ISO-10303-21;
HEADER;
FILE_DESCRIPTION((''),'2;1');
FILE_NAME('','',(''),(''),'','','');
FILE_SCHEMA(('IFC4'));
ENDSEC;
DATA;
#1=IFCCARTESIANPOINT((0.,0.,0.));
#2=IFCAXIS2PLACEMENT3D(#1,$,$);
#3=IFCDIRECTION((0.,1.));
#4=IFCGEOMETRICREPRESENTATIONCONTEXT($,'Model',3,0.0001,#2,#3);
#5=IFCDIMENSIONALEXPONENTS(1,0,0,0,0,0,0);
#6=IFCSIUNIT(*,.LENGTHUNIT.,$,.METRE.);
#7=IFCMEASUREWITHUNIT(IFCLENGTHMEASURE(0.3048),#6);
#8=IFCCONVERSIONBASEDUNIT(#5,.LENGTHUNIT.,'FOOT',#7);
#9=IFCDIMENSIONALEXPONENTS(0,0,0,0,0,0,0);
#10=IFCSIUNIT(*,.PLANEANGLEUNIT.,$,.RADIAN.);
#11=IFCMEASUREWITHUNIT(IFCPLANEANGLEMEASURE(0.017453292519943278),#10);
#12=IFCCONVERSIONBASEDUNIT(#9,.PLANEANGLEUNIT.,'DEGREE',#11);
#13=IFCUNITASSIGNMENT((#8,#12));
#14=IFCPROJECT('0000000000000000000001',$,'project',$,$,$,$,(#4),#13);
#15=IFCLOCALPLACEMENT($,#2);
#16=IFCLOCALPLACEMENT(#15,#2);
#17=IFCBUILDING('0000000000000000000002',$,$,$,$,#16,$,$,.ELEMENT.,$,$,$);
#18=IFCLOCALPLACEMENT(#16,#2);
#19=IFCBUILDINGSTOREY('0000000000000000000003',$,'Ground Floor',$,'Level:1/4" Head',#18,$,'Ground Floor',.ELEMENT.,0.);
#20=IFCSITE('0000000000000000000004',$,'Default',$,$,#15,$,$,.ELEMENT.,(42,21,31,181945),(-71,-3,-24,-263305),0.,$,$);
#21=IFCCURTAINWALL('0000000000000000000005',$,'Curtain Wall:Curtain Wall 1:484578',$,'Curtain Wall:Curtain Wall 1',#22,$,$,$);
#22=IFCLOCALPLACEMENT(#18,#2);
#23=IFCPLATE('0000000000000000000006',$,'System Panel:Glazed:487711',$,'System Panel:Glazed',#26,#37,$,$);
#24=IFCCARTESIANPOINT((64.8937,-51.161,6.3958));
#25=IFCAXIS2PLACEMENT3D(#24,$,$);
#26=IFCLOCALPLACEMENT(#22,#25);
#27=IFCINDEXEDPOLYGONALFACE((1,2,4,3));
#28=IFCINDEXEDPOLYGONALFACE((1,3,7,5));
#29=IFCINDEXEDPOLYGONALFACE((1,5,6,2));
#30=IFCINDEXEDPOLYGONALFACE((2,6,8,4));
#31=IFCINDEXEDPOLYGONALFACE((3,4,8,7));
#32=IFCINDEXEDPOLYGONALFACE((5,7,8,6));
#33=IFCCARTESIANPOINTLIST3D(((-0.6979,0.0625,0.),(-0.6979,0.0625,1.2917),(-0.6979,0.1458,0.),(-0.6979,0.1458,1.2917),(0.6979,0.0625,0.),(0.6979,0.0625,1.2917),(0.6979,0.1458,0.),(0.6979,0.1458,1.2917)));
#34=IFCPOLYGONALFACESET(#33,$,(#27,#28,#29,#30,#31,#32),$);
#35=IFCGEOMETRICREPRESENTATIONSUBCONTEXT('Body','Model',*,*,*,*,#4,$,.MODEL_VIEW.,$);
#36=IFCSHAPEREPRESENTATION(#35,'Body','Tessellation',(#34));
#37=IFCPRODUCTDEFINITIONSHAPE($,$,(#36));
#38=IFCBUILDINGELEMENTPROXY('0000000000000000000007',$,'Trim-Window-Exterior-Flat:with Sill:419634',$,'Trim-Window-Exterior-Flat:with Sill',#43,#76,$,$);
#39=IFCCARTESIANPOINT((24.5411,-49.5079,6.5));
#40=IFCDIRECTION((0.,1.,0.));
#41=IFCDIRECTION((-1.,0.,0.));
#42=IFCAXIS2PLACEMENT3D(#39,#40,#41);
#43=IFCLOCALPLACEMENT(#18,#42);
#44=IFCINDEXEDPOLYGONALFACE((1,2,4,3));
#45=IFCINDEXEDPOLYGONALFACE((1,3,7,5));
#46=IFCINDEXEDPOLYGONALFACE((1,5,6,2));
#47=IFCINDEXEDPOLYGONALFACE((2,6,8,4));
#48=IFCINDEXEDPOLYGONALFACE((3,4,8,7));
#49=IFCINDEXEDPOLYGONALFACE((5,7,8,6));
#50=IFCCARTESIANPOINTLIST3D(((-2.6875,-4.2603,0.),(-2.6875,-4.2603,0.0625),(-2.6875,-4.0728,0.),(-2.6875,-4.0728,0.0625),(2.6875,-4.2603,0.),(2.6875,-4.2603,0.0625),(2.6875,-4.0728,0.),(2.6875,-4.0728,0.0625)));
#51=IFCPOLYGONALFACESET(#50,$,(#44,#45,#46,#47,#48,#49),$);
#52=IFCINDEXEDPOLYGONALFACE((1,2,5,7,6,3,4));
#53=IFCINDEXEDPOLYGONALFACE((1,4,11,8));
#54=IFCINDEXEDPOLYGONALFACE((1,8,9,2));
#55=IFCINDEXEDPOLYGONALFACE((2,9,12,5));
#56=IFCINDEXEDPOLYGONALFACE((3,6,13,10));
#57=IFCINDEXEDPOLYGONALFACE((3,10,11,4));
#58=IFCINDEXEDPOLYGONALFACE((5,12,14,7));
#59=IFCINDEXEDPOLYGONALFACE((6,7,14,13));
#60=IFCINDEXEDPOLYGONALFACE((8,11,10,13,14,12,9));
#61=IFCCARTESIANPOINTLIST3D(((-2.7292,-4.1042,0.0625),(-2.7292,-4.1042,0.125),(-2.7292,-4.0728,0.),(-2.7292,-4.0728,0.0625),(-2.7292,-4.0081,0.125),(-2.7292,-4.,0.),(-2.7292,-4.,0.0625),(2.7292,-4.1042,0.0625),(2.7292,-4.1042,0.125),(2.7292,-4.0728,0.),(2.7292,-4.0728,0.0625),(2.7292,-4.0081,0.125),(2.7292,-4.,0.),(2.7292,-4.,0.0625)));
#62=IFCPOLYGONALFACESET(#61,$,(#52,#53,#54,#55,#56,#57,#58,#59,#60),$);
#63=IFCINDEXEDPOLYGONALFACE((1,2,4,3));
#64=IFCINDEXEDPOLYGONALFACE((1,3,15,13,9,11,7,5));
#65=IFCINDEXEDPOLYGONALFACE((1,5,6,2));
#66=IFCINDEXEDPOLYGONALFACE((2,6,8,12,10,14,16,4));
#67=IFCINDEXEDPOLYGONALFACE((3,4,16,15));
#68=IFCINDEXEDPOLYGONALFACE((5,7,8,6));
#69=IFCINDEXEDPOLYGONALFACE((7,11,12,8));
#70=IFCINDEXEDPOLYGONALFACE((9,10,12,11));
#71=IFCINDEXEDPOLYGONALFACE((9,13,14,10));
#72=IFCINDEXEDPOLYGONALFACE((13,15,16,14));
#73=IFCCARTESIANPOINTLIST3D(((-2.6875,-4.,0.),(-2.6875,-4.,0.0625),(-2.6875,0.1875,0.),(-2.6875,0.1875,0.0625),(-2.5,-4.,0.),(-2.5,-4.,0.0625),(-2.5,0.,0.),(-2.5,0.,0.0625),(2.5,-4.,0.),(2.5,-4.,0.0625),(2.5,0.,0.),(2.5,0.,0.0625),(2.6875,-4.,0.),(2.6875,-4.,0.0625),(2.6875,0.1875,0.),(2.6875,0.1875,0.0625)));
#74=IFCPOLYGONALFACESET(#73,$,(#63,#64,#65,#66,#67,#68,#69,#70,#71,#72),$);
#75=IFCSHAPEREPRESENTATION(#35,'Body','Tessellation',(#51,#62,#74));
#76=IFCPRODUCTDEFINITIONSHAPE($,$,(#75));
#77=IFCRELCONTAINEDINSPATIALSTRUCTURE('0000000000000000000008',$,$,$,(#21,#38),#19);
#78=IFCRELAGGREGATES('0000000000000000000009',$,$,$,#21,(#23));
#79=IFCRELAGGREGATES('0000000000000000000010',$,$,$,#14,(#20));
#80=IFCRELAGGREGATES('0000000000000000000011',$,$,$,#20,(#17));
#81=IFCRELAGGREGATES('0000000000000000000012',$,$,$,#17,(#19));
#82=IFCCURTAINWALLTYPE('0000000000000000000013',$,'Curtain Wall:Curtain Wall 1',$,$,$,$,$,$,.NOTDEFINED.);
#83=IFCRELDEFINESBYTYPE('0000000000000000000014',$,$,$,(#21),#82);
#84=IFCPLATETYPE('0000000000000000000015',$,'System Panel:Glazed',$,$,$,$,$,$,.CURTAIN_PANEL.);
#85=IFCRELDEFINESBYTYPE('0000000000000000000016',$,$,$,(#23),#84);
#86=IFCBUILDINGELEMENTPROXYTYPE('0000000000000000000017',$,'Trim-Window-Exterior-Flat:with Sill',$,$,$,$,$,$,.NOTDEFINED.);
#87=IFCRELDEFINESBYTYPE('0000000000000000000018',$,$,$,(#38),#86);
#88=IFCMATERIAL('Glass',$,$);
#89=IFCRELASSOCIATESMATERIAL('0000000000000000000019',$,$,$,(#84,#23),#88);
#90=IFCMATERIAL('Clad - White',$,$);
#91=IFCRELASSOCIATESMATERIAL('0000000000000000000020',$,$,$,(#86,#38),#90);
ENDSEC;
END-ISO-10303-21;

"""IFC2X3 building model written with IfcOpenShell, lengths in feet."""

from ifc_helpers import new_model, entity, si_unit, converted_unit, direction, frame, frame_2d, origin, origin_2d_with_axis, place, context, subcontext, project, spatial, polyline, rectangle, outline, extrude, source, transform, mapped, material, type_object, type_shapes, element, aggregate, save


model = new_model("IFC2X3")

# Units and contexts
model_context = context("Model", 3, precision=0.0001, world=origin(), true_north=direction((0.0, 1.0)))
body_context = subcontext(model_context, "Body", "Model", "MODEL_VIEW")
ifc_project = project(units=[converted_unit("LENGTHUNIT", "FOOT", entity("IfcLengthMeasure", 0.3048), si_unit("LENGTHUNIT", "METRE"), dimensions=[1, 0, 0, 0, 0, 0, 0]), converted_unit("PLANEANGLEUNIT", "DEGREE", entity("IfcPlaneAngleMeasure", 0.017453292519943278), si_unit("PLANEANGLEUNIT", "RADIAN"), dimensions=[0, 0, 0, 0, 0, 0, 0])], contexts=[model_context])

# Site, building, storey
site_placement = place(None, origin())
site = spatial("IfcSite", under=ifc_project, at=site_placement, Name="Default", CompositionType="ELEMENT", RefLatitude=(42, 21, 31, 181945), RefLongitude=(-71, -3, -24, -263305), RefElevation=0.0)
building_placement = place(site_placement, origin())
building = spatial("IfcBuilding", under=site, at=building_placement, CompositionType="ELEMENT")
storey_placement = place(building_placement, origin())
storey = spatial("IfcBuildingStorey", under=building, at=storey_placement, Name="Ground Floor", ObjectType="Level:1/4\" Head", LongName="Ground Floor", CompositionType="ELEMENT", Elevation=0.0)

# Curtain wall
curtain_wall_type = type_object("IfcCurtainWallType", Name="Curtain Wall:Curtain Wall 1", PredefinedType="NOTDEFINED")
curtain_wall_placement = place(storey_placement, origin())
curtain_wall = element("IfcCurtainWall", 1, at=curtain_wall_placement, inside=storey, type_object=curtain_wall_type, Name="Curtain Wall:Curtain Wall 1:484578", ObjectType="Curtain Wall:Curtain Wall 1")

# Plate
ifc_material_1 = material(Name="Glass")
plate_type = type_object("IfcPlateType", Name="System Panel:Glazed", PredefinedType="CURTAIN_PANEL", material=ifc_material_1)
shared_shape_1 = source(origin(), body_context, "Body", "SweptSolid", [
    extrude(rectangle(XDim=0.0833, YDim=1.3958, at=frame_2d((0.0, 0.0), x_axis=(1.0, 0.0))), frame((0.0, 0.1042, 0.0), z_axis=(0.0, 0.0, 1.0), x_axis=(0.0, 1.0, 0.0)), (0.0, 0.0, 1.0), 1.2917),
])
type_shapes(plate_type, [shared_shape_1])
plate_placement = place(curtain_wall_placement, frame((64.8937, -51.161, 6.3958)))
plate = element("IfcPlate", 2, at=plate_placement, type_object=plate_type, material=ifc_material_1, Name="System Panel:Glazed:487711", ObjectType="System Panel:Glazed", context=body_context, shape_type="MappedRepresentation", body=[
    mapped(shared_shape_1, transform((0.0, 0.0, 0.0), scale=1.0)),
])
aggregate(curtain_wall, [plate])

# Building element proxy
ifc_material_2 = material(Name="Clad - White")
building_element_proxy_type_1 = type_object("IfcBuildingElementProxyType", Name="Trim-Window-Exterior-Flat:with Sill", PredefinedType="NOTDEFINED", material=ifc_material_2)
shared_shape_2 = source(origin(), body_context, "Body", "SweptSolid", [
    extrude(rectangle(XDim=5.375, YDim=0.1875, at=origin_2d_with_axis()), frame((0.0, -4.1665, 0.0), z_axis=(0.0, 0.0, 1.0), x_axis=(-1.0, 0.0, 0.0)), (0.0, 0.0, 1.0), 0.0625),
    extrude(outline(polyline([(-0.0625, -0.0525), (0.0, -0.0525), (0.0, -0.0211), (0.0625, -0.0211), (0.0625, 0.0517), (0.0, 0.0517), (-0.0625, 0.0436), (-0.0625, -0.0525)])), frame((-2.7292, -4.0517, 0.0625), z_axis=(1.0, 0.0, 0.0), x_axis=(0.0, 0.0, -1.0)), (0.0, 0.0, 1.0), 5.4583),
    extrude(outline(polyline([(-2.1406, -2.6875), (2.0469, -2.6875), (2.0469, -2.5), (-1.9531, -2.5), (-1.9531, 2.5), (2.0469, 2.5), (2.0469, 2.6875), (-2.1406, 2.6875), (-2.1406, -2.6875)])), frame((0.0, -1.9531, 0.0), z_axis=(0.0, 0.0, 1.0), x_axis=(0.0, -1.0, 0.0)), (0.0, 0.0, 1.0), 0.0625),
])
type_shapes(building_element_proxy_type_1, [shared_shape_2])
proxy_1_placement = place(storey_placement, frame((24.5411, -49.5079, 6.5), z_axis=(0.0, 1.0, 0.0), x_axis=(-1.0, 0.0, 0.0)))
element("IfcBuildingElementProxy", 3, at=proxy_1_placement, inside=storey, type_object=building_element_proxy_type_1, material=ifc_material_2, Name="Trim-Window-Exterior-Flat:with Sill:419634", ObjectType="Trim-Window-Exterior-Flat:with Sill", context=body_context, shape_type="MappedRepresentation", body=[
    mapped(shared_shape_2, transform((0.0, 0.0, 0.0), scale=1.0)),
])

save(model, "model.ifc")
